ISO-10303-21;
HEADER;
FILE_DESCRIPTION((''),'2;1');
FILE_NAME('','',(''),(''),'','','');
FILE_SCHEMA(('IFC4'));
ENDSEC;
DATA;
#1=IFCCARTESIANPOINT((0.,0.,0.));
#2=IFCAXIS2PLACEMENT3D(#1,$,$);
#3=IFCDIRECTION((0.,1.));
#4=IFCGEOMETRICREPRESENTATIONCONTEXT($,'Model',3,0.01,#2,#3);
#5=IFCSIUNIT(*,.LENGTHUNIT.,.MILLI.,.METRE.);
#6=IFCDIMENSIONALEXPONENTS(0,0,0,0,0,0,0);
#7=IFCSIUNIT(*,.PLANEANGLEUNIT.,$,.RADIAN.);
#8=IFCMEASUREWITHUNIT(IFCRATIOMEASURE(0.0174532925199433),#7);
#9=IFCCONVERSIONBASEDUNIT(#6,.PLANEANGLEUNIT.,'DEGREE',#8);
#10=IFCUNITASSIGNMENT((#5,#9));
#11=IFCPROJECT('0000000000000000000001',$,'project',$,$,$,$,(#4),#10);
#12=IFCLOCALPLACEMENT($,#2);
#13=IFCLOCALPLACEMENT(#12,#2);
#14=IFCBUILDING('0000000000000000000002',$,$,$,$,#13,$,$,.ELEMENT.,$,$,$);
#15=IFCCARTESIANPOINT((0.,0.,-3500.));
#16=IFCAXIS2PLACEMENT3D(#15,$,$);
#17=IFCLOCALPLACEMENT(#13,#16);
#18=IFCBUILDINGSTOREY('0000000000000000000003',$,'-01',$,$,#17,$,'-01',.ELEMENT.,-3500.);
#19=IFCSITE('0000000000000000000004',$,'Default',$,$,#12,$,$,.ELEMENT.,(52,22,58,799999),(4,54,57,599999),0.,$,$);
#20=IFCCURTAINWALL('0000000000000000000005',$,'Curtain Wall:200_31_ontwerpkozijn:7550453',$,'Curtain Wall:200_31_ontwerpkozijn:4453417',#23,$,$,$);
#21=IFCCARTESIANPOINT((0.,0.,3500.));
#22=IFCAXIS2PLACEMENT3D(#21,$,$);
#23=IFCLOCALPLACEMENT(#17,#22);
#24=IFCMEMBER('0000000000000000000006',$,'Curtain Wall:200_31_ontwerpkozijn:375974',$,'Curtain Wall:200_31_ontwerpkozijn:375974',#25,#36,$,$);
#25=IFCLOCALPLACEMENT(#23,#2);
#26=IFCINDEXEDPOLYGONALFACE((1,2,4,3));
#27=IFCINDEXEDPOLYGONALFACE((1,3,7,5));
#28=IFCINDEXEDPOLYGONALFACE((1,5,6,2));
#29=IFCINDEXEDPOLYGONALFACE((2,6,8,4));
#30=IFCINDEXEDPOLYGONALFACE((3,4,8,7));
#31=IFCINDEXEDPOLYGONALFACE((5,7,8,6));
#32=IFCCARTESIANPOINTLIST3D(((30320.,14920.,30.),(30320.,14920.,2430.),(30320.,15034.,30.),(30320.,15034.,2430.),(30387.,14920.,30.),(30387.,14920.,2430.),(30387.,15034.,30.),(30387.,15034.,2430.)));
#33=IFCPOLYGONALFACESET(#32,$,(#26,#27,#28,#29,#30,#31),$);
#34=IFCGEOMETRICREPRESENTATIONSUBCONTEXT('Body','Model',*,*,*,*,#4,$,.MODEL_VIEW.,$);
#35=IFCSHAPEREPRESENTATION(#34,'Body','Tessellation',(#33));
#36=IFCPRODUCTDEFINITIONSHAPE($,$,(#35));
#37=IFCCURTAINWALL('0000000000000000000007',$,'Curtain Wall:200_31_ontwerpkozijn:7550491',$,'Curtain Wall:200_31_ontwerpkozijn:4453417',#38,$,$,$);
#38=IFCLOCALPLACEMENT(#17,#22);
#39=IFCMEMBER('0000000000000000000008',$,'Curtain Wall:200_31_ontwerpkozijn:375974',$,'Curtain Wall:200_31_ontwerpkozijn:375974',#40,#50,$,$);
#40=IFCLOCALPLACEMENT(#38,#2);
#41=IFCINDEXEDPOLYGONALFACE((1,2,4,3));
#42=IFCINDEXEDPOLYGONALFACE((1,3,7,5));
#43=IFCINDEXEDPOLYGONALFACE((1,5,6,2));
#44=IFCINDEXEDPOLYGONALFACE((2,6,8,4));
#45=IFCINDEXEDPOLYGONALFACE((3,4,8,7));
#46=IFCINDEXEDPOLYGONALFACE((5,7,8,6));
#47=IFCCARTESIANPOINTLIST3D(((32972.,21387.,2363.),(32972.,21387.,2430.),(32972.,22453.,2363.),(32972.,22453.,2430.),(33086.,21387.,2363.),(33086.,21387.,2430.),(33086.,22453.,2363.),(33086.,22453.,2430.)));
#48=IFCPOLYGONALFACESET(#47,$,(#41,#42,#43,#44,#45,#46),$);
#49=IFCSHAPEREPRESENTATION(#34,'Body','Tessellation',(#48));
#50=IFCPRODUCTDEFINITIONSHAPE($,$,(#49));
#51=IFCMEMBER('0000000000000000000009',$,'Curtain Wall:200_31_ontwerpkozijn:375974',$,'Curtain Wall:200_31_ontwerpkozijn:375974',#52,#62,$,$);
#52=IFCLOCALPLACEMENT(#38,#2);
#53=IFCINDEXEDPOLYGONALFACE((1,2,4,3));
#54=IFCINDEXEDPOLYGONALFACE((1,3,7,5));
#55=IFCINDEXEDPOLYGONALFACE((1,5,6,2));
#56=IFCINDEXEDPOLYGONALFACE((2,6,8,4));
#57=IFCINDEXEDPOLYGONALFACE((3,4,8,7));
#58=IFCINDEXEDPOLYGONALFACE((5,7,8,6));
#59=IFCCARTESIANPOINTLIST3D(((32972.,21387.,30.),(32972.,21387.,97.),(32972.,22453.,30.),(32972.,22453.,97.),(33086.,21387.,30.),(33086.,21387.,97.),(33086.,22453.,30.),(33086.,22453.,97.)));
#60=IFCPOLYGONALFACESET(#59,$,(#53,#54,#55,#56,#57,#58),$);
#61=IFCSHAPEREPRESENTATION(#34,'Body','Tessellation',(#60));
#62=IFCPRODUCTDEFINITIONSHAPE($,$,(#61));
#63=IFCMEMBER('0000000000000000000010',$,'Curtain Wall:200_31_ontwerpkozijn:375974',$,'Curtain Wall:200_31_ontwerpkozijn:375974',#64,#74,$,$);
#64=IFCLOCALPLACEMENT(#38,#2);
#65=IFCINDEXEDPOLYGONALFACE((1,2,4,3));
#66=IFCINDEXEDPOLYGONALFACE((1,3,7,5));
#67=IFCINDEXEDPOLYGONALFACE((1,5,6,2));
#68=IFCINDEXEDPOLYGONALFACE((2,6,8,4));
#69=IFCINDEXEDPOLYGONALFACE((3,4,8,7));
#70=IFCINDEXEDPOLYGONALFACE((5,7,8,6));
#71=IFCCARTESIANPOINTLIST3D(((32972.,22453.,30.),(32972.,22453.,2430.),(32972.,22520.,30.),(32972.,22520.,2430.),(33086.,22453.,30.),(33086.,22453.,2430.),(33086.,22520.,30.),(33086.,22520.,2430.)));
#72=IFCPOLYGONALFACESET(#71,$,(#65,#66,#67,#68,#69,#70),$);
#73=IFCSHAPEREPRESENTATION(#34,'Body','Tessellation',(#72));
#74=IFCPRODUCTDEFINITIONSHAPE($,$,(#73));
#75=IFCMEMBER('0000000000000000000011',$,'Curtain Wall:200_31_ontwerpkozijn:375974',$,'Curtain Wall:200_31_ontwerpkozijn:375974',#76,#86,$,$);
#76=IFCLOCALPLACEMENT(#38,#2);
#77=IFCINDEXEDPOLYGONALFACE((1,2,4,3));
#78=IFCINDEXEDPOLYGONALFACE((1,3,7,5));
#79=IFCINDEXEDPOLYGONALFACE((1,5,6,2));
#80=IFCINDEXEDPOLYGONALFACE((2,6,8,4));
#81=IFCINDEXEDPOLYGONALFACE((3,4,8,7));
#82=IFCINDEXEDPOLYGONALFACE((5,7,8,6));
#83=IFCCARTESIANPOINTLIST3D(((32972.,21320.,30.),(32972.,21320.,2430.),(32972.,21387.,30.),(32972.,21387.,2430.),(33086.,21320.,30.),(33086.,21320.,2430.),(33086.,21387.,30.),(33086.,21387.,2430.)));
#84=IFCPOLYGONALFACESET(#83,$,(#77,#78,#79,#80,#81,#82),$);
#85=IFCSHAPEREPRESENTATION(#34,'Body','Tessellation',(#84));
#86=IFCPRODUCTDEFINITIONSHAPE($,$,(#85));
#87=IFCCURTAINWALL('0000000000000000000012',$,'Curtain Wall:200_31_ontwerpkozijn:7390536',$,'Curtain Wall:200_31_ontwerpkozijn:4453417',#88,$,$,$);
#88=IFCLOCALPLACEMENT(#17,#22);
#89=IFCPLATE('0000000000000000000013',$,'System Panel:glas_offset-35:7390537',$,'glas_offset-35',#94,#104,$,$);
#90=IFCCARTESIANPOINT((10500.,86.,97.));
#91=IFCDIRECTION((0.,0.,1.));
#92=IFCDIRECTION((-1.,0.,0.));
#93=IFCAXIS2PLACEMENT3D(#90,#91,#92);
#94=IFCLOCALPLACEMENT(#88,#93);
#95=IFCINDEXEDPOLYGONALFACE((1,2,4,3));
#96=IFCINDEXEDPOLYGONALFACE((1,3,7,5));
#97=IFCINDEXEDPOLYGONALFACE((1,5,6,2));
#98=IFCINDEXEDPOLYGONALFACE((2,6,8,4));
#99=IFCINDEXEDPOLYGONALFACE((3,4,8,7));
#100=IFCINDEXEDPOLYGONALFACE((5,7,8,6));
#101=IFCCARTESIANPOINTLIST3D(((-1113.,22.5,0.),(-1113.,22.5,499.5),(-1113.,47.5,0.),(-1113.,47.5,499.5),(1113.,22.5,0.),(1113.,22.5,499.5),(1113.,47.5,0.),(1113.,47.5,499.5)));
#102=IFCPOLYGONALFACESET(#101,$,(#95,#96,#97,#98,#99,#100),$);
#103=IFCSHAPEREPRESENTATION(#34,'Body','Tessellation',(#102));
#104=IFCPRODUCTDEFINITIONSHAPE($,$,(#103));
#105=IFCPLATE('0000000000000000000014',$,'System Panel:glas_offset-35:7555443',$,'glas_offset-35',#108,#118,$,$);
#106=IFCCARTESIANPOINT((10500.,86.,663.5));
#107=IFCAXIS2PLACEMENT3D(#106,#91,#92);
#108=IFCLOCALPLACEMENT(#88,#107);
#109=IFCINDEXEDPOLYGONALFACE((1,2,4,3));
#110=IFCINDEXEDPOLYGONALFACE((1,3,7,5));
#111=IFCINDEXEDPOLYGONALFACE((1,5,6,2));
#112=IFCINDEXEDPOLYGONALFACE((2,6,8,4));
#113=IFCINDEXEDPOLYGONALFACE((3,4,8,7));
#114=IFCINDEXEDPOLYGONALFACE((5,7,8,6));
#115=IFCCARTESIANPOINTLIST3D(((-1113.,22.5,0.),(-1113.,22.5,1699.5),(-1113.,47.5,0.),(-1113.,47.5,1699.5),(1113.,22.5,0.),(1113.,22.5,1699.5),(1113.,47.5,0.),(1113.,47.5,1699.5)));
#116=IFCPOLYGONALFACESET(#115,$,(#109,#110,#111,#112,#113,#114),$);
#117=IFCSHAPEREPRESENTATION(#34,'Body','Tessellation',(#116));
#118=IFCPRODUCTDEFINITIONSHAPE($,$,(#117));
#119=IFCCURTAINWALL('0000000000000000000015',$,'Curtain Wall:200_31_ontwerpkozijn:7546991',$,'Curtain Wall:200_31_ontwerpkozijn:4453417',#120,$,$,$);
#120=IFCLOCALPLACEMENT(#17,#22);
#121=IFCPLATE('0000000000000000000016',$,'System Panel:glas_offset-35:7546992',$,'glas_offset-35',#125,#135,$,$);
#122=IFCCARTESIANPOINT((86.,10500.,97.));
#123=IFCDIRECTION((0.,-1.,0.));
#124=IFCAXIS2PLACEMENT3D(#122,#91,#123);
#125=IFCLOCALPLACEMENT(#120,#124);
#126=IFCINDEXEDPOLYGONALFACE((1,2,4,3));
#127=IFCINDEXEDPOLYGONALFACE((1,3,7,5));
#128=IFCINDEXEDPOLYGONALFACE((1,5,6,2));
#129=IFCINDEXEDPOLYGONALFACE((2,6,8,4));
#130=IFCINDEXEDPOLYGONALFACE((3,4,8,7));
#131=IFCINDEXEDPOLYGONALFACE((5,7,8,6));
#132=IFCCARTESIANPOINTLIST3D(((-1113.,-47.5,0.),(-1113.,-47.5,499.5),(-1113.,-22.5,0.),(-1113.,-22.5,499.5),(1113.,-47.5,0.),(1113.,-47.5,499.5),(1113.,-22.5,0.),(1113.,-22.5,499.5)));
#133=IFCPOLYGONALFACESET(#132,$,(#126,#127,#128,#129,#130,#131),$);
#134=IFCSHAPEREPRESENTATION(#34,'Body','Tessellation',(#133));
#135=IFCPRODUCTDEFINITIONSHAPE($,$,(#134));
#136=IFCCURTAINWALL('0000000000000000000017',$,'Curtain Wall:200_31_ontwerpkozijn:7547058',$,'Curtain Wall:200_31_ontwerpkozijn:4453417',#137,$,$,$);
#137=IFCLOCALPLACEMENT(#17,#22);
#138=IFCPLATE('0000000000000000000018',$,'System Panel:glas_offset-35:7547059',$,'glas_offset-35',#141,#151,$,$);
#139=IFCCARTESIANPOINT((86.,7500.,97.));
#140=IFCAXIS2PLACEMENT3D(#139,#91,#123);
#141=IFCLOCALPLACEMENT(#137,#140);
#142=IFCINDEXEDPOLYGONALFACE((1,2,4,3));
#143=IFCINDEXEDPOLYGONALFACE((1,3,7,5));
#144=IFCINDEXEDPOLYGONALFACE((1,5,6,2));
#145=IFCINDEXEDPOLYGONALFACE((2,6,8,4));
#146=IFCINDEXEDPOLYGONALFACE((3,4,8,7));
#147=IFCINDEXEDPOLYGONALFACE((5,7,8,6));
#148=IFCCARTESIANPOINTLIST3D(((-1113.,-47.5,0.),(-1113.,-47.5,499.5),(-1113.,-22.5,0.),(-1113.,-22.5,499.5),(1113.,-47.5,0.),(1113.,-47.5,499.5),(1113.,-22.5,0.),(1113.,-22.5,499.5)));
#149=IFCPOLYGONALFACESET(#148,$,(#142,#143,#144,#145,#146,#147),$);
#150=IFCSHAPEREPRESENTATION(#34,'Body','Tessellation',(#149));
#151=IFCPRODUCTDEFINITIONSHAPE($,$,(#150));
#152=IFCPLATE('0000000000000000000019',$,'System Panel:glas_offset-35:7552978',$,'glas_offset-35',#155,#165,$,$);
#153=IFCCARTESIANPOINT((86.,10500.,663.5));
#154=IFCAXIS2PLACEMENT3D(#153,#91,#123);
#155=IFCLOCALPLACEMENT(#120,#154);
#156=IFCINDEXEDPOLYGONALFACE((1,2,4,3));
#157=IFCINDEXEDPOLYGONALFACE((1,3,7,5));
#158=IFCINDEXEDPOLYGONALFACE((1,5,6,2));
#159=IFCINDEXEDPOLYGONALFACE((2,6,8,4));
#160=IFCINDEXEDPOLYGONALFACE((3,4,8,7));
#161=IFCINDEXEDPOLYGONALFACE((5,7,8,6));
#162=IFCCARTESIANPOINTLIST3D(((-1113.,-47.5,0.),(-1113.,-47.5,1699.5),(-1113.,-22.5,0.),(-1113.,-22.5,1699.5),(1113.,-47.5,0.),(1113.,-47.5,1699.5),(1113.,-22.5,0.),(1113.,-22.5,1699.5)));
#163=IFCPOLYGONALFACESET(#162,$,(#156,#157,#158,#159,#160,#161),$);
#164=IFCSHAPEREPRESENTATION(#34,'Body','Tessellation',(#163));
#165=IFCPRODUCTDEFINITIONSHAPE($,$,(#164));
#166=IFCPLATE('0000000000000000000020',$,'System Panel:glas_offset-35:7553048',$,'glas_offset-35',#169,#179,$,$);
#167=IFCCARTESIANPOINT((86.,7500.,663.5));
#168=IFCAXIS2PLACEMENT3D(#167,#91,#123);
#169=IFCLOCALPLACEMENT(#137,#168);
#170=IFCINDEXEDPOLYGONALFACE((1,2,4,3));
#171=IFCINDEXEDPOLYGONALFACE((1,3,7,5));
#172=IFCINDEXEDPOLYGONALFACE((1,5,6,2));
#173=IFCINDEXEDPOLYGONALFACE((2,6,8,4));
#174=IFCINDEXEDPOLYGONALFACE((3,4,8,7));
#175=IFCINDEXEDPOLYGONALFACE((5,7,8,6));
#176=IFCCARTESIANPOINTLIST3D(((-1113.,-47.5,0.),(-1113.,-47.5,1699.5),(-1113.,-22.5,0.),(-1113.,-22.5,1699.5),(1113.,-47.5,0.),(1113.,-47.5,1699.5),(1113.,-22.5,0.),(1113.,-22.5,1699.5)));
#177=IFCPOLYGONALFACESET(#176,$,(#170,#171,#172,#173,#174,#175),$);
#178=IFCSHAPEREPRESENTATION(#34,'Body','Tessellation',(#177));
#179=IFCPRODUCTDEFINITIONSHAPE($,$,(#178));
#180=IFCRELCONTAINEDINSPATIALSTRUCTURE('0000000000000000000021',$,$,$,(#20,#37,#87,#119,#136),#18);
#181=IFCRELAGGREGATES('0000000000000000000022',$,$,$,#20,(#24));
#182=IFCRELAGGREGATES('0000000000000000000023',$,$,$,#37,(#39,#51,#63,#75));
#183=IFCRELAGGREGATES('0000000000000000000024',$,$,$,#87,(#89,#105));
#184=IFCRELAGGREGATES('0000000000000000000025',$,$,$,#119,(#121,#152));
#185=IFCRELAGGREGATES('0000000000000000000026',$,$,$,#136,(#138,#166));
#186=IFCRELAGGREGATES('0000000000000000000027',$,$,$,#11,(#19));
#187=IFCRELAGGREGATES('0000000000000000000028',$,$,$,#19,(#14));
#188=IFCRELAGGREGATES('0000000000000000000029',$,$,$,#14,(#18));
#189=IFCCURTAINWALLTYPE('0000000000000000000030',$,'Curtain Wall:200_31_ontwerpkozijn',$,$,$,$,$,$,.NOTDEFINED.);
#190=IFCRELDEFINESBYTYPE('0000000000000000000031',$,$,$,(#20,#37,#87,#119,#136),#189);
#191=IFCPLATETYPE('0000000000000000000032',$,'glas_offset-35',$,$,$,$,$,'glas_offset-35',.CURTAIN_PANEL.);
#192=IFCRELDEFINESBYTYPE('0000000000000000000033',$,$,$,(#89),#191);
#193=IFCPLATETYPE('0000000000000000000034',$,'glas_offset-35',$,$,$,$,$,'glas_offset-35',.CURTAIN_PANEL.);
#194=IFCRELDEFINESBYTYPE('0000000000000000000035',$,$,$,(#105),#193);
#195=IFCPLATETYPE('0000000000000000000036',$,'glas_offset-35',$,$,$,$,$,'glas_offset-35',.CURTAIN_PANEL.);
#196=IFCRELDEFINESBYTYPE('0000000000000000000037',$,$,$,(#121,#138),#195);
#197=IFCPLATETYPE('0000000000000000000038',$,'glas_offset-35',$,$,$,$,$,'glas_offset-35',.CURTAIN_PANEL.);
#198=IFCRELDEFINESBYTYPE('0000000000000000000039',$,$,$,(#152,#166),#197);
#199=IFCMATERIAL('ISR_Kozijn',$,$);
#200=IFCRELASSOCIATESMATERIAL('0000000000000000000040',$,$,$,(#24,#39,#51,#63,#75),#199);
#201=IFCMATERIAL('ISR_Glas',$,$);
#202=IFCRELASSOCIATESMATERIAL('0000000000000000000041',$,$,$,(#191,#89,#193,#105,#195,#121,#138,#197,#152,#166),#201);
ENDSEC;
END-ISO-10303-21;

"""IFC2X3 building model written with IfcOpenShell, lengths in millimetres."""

from ifc_helpers import new_model, entity, si_unit, converted_unit, direction, frame, frame_2d, origin, origin_2d_with_axis, place, context, subcontext, project, spatial, rectangle, extrude, source, transform, mapped, material, type_object, type_shapes, element, aggregate, save


model = new_model("IFC2X3")

# Units and contexts
model_context = context("Model", 3, precision=0.01, world=origin(), true_north=direction((0.0, 1.0)))
body_context = subcontext(model_context, "Body", "Model", "MODEL_VIEW")
ifc_project = project(units=[si_unit("LENGTHUNIT", "METRE", prefix="MILLI"), converted_unit("PLANEANGLEUNIT", "DEGREE", entity("IfcRatioMeasure", 0.0174532925199433), si_unit("PLANEANGLEUNIT", "RADIAN"), dimensions=[0, 0, 0, 0, 0, 0, 0])], contexts=[model_context])

# Site, building, storey
site_placement = place(None, origin())
site = spatial("IfcSite", under=ifc_project, at=site_placement, Name="Default", CompositionType="ELEMENT", RefLatitude=(52, 22, 58, 799999), RefLongitude=(4, 54, 57, 599999), RefElevation=0.0)
building_placement = place(site_placement, origin())
building = spatial("IfcBuilding", under=site, at=building_placement, CompositionType="ELEMENT")
storey_placement = place(building_placement, frame((0.0, 0.0, -3500.0)))
storey = spatial("IfcBuildingStorey", under=building, at=storey_placement, Name="-01", LongName="-01", CompositionType="ELEMENT", Elevation=-3500.0)

# Curtain walls, members
curtain_wall_type = type_object("IfcCurtainWallType", Name="Curtain Wall:200_31_ontwerpkozijn", PredefinedType="NOTDEFINED")
ifc_material_1 = material(Name="ISR_Kozijn")
curtain_wall_1_placement = place(storey_placement, frame((0.0, 0.0, 3500.0)))
curtain_wall_1 = element("IfcCurtainWall", 1, at=curtain_wall_1_placement, inside=storey, type_object=curtain_wall_type, Name="Curtain Wall:200_31_ontwerpkozijn:7550453", ObjectType="Curtain Wall:200_31_ontwerpkozijn:4453417")
member_1_placement = place(curtain_wall_1_placement, origin())
member_1 = element("IfcMember", 2, at=member_1_placement, material=ifc_material_1, Name="Curtain Wall:200_31_ontwerpkozijn:375974", ObjectType="Curtain Wall:200_31_ontwerpkozijn:375974", context=body_context, shape_type="SweptSolid", body=[
    extrude(rectangle(XDim=67.0, YDim=114.0, at=origin_2d_with_axis()), frame((30353.5, 14977.0, 2430.0), z_axis=(0.0, 0.0, -1.0), x_axis=(-1.0, 0.0, 0.0)), (0.0, 0.0, 1.0), 2400.0),
])
aggregate(curtain_wall_1, [member_1])
curtain_wall_2_placement = place(storey_placement, frame((0.0, 0.0, 3500.0)))
curtain_wall_2 = element("IfcCurtainWall", 3, at=curtain_wall_2_placement, inside=storey, type_object=curtain_wall_type, Name="Curtain Wall:200_31_ontwerpkozijn:7550491", ObjectType="Curtain Wall:200_31_ontwerpkozijn:4453417")
member_2_placement = place(curtain_wall_2_placement, origin())
member_2 = element("IfcMember", 4, at=member_2_placement, material=ifc_material_1, Name="Curtain Wall:200_31_ontwerpkozijn:375974", ObjectType="Curtain Wall:200_31_ontwerpkozijn:375974", context=body_context, shape_type="SweptSolid", body=[
    extrude(rectangle(XDim=67.0, YDim=114.0, at=origin_2d_with_axis()), frame((33029.0, 22453.0, 2396.5), z_axis=(0.0, -1.0, 0.0), x_axis=(0.0, 0.0, -1.0)), (0.0, 0.0, 1.0), 1066.0),
])
member_3_placement = place(curtain_wall_2_placement, origin())
member_3 = element("IfcMember", 5, at=member_3_placement, material=ifc_material_1, Name="Curtain Wall:200_31_ontwerpkozijn:375974", ObjectType="Curtain Wall:200_31_ontwerpkozijn:375974", context=body_context, shape_type="SweptSolid", body=[
    extrude(rectangle(XDim=67.0, YDim=114.0, at=frame_2d((0.0, 0.0), x_axis=(1.0, 0.0))), frame((33029.0, 21387.0, 63.5), z_axis=(0.0, 1.0, 0.0), x_axis=(0.0, 0.0, -1.0)), (0.0, 0.0, 1.0), 1066.0),
])
member_4_placement = place(curtain_wall_2_placement, origin())
member_4 = element("IfcMember", 6, at=member_4_placement, material=ifc_material_1, Name="Curtain Wall:200_31_ontwerpkozijn:375974", ObjectType="Curtain Wall:200_31_ontwerpkozijn:375974", context=body_context, shape_type="SweptSolid", body=[
    extrude(rectangle(XDim=114.0, YDim=67.0, at=origin_2d_with_axis()), frame((33029.0, 22486.5, 30.0), z_axis=(0.0, 0.0, 1.0), x_axis=(-1.0, 0.0, 0.0)), (0.0, 0.0, 1.0), 2400.0),
])
member_5_placement = place(curtain_wall_2_placement, origin())
member_5 = element("IfcMember", 7, at=member_5_placement, material=ifc_material_1, Name="Curtain Wall:200_31_ontwerpkozijn:375974", ObjectType="Curtain Wall:200_31_ontwerpkozijn:375974", context=body_context, shape_type="SweptSolid", body=[
    extrude(rectangle(XDim=114.0, YDim=67.0, at=origin_2d_with_axis()), frame((33029.0, 21353.5, 2430.0), z_axis=(0.0, 0.0, -1.0), x_axis=(-1.0, 0.0, 0.0)), (0.0, 0.0, 1.0), 2400.0),
])
aggregate(curtain_wall_2, [member_2, member_3, member_4, member_5])

# Curtain wall, plates
curtain_wall_3_placement = place(storey_placement, frame((0.0, 0.0, 3500.0)))
curtain_wall_3 = element("IfcCurtainWall", 8, at=curtain_wall_3_placement, inside=storey, type_object=curtain_wall_type, Name="Curtain Wall:200_31_ontwerpkozijn:7390536", ObjectType="Curtain Wall:200_31_ontwerpkozijn:4453417")
ifc_material_2 = material(Name="ISR_Glas")
plate_type_1 = type_object("IfcPlateType", Name="glas_offset-35", ElementType="glas_offset-35", PredefinedType="CURTAIN_PANEL", material=ifc_material_2)
shared_shape_1 = source(origin(), body_context, "Body", "SweptSolid", [
    extrude(rectangle(XDim=25.0, YDim=2226.0, at=origin_2d_with_axis()), frame((0.0, 35.0, 0.0), z_axis=(0.0, 0.0, 1.0), x_axis=(0.0, 1.0, 0.0)), (0.0, 0.0, 1.0), 499.5),
])
type_shapes(plate_type_1, [shared_shape_1])
plate_1_placement = place(curtain_wall_3_placement, frame((10500.0, 86.0, 97.0), z_axis=(0.0, 0.0, 1.0), x_axis=(-1.0, 0.0, 0.0)))
plate_1 = element("IfcPlate", 9, at=plate_1_placement, type_object=plate_type_1, material=ifc_material_2, Name="System Panel:glas_offset-35:7390537", ObjectType="glas_offset-35", context=body_context, shape_type="MappedRepresentation", body=[
    mapped(shared_shape_1, transform((0.0, 0.0, 0.0), scale=1.0)),
])
plate_type_2 = type_object("IfcPlateType", Name="glas_offset-35", ElementType="glas_offset-35", PredefinedType="CURTAIN_PANEL", material=ifc_material_2)
shared_shape_2 = source(origin(), body_context, "Body", "SweptSolid", [
    extrude(rectangle(XDim=25.0, YDim=2226.0, at=origin_2d_with_axis()), frame((0.0, 35.0, 0.0), z_axis=(0.0, 0.0, 1.0), x_axis=(0.0, 1.0, 0.0)), (0.0, 0.0, 1.0), 1699.5),
])
type_shapes(plate_type_2, [shared_shape_2])
plate_2_placement = place(curtain_wall_3_placement, frame((10500.0, 86.0, 663.5), z_axis=(0.0, 0.0, 1.0), x_axis=(-1.0, 0.0, 0.0)))
plate_2 = element("IfcPlate", 10, at=plate_2_placement, type_object=plate_type_2, material=ifc_material_2, Name="System Panel:glas_offset-35:7555443", ObjectType="glas_offset-35", context=body_context, shape_type="MappedRepresentation", body=[
    mapped(shared_shape_2, transform((0.0, 0.0, 0.0), scale=1.0)),
])
aggregate(curtain_wall_3, [plate_1, plate_2])

# Curtain walls, plates
curtain_wall_4_placement = place(storey_placement, frame((0.0, 0.0, 3500.0)))
curtain_wall_4 = element("IfcCurtainWall", 11, at=curtain_wall_4_placement, inside=storey, type_object=curtain_wall_type, Name="Curtain Wall:200_31_ontwerpkozijn:7546991", ObjectType="Curtain Wall:200_31_ontwerpkozijn:4453417")
plate_type_3 = type_object("IfcPlateType", Name="glas_offset-35", ElementType="glas_offset-35", PredefinedType="CURTAIN_PANEL", material=ifc_material_2)
shared_shape_3 = source(origin(), body_context, "Body", "SweptSolid", [
    extrude(rectangle(XDim=25.0, YDim=2226.0, at=frame_2d((0.0, 0.0), x_axis=(1.0, 0.0))), frame((0.0, -35.0, 0.0), z_axis=(0.0, 0.0, 1.0), x_axis=(0.0, 1.0, 0.0)), (0.0, 0.0, 1.0), 499.5),
])
type_shapes(plate_type_3, [shared_shape_3])
plate_3_placement = place(curtain_wall_4_placement, frame((86.0, 10500.0, 97.0), z_axis=(0.0, 0.0, 1.0), x_axis=(0.0, -1.0, 0.0)))
plate_3 = element("IfcPlate", 12, at=plate_3_placement, type_object=plate_type_3, material=ifc_material_2, Name="System Panel:glas_offset-35:7546992", ObjectType="glas_offset-35", context=body_context, shape_type="MappedRepresentation", body=[
    mapped(shared_shape_3, transform((0.0, 0.0, 0.0), scale=1.0)),
])
curtain_wall_5_placement = place(storey_placement, frame((0.0, 0.0, 3500.0)))
curtain_wall_5 = element("IfcCurtainWall", 13, at=curtain_wall_5_placement, inside=storey, type_object=curtain_wall_type, Name="Curtain Wall:200_31_ontwerpkozijn:7547058", ObjectType="Curtain Wall:200_31_ontwerpkozijn:4453417")
plate_4_placement = place(curtain_wall_5_placement, frame((86.0, 7500.0, 97.0), z_axis=(0.0, 0.0, 1.0), x_axis=(0.0, -1.0, 0.0)))
plate_4 = element("IfcPlate", 14, at=plate_4_placement, type_object=plate_type_3, material=ifc_material_2, Name="System Panel:glas_offset-35:7547059", ObjectType="glas_offset-35", context=body_context, shape_type="MappedRepresentation", body=[
    mapped(shared_shape_3, transform((0.0, 0.0, 0.0), scale=1.0)),
])

# Plates
plate_type_4 = type_object("IfcPlateType", Name="glas_offset-35", ElementType="glas_offset-35", PredefinedType="CURTAIN_PANEL", material=ifc_material_2)
shared_shape_4 = source(origin(), body_context, "Body", "SweptSolid", [
    extrude(rectangle(XDim=25.0, YDim=2226.0, at=frame_2d((0.0, 0.0), x_axis=(1.0, 0.0))), frame((0.0, -35.0, 0.0), z_axis=(0.0, 0.0, 1.0), x_axis=(0.0, 1.0, 0.0)), (0.0, 0.0, 1.0), 1699.5),
])
type_shapes(plate_type_4, [shared_shape_4])
plate_5_placement = place(curtain_wall_4_placement, frame((86.0, 10500.0, 663.5), z_axis=(0.0, 0.0, 1.0), x_axis=(0.0, -1.0, 0.0)))
plate_5 = element("IfcPlate", 15, at=plate_5_placement, type_object=plate_type_4, material=ifc_material_2, Name="System Panel:glas_offset-35:7552978", ObjectType="glas_offset-35", context=body_context, shape_type="MappedRepresentation", body=[
    mapped(shared_shape_4, transform((0.0, 0.0, 0.0), scale=1.0)),
])
aggregate(curtain_wall_4, [plate_3, plate_5])
plate_6_placement = place(curtain_wall_5_placement, frame((86.0, 7500.0, 663.5), z_axis=(0.0, 0.0, 1.0), x_axis=(0.0, -1.0, 0.0)))
plate_6 = element("IfcPlate", 16, at=plate_6_placement, type_object=plate_type_4, material=ifc_material_2, Name="System Panel:glas_offset-35:7553048", ObjectType="glas_offset-35", context=body_context, shape_type="MappedRepresentation", body=[
    mapped(shared_shape_4, transform((0.0, 0.0, 0.0), scale=1.0)),
])
aggregate(curtain_wall_5, [plate_4, plate_6])

save(model, "model.ifc")
